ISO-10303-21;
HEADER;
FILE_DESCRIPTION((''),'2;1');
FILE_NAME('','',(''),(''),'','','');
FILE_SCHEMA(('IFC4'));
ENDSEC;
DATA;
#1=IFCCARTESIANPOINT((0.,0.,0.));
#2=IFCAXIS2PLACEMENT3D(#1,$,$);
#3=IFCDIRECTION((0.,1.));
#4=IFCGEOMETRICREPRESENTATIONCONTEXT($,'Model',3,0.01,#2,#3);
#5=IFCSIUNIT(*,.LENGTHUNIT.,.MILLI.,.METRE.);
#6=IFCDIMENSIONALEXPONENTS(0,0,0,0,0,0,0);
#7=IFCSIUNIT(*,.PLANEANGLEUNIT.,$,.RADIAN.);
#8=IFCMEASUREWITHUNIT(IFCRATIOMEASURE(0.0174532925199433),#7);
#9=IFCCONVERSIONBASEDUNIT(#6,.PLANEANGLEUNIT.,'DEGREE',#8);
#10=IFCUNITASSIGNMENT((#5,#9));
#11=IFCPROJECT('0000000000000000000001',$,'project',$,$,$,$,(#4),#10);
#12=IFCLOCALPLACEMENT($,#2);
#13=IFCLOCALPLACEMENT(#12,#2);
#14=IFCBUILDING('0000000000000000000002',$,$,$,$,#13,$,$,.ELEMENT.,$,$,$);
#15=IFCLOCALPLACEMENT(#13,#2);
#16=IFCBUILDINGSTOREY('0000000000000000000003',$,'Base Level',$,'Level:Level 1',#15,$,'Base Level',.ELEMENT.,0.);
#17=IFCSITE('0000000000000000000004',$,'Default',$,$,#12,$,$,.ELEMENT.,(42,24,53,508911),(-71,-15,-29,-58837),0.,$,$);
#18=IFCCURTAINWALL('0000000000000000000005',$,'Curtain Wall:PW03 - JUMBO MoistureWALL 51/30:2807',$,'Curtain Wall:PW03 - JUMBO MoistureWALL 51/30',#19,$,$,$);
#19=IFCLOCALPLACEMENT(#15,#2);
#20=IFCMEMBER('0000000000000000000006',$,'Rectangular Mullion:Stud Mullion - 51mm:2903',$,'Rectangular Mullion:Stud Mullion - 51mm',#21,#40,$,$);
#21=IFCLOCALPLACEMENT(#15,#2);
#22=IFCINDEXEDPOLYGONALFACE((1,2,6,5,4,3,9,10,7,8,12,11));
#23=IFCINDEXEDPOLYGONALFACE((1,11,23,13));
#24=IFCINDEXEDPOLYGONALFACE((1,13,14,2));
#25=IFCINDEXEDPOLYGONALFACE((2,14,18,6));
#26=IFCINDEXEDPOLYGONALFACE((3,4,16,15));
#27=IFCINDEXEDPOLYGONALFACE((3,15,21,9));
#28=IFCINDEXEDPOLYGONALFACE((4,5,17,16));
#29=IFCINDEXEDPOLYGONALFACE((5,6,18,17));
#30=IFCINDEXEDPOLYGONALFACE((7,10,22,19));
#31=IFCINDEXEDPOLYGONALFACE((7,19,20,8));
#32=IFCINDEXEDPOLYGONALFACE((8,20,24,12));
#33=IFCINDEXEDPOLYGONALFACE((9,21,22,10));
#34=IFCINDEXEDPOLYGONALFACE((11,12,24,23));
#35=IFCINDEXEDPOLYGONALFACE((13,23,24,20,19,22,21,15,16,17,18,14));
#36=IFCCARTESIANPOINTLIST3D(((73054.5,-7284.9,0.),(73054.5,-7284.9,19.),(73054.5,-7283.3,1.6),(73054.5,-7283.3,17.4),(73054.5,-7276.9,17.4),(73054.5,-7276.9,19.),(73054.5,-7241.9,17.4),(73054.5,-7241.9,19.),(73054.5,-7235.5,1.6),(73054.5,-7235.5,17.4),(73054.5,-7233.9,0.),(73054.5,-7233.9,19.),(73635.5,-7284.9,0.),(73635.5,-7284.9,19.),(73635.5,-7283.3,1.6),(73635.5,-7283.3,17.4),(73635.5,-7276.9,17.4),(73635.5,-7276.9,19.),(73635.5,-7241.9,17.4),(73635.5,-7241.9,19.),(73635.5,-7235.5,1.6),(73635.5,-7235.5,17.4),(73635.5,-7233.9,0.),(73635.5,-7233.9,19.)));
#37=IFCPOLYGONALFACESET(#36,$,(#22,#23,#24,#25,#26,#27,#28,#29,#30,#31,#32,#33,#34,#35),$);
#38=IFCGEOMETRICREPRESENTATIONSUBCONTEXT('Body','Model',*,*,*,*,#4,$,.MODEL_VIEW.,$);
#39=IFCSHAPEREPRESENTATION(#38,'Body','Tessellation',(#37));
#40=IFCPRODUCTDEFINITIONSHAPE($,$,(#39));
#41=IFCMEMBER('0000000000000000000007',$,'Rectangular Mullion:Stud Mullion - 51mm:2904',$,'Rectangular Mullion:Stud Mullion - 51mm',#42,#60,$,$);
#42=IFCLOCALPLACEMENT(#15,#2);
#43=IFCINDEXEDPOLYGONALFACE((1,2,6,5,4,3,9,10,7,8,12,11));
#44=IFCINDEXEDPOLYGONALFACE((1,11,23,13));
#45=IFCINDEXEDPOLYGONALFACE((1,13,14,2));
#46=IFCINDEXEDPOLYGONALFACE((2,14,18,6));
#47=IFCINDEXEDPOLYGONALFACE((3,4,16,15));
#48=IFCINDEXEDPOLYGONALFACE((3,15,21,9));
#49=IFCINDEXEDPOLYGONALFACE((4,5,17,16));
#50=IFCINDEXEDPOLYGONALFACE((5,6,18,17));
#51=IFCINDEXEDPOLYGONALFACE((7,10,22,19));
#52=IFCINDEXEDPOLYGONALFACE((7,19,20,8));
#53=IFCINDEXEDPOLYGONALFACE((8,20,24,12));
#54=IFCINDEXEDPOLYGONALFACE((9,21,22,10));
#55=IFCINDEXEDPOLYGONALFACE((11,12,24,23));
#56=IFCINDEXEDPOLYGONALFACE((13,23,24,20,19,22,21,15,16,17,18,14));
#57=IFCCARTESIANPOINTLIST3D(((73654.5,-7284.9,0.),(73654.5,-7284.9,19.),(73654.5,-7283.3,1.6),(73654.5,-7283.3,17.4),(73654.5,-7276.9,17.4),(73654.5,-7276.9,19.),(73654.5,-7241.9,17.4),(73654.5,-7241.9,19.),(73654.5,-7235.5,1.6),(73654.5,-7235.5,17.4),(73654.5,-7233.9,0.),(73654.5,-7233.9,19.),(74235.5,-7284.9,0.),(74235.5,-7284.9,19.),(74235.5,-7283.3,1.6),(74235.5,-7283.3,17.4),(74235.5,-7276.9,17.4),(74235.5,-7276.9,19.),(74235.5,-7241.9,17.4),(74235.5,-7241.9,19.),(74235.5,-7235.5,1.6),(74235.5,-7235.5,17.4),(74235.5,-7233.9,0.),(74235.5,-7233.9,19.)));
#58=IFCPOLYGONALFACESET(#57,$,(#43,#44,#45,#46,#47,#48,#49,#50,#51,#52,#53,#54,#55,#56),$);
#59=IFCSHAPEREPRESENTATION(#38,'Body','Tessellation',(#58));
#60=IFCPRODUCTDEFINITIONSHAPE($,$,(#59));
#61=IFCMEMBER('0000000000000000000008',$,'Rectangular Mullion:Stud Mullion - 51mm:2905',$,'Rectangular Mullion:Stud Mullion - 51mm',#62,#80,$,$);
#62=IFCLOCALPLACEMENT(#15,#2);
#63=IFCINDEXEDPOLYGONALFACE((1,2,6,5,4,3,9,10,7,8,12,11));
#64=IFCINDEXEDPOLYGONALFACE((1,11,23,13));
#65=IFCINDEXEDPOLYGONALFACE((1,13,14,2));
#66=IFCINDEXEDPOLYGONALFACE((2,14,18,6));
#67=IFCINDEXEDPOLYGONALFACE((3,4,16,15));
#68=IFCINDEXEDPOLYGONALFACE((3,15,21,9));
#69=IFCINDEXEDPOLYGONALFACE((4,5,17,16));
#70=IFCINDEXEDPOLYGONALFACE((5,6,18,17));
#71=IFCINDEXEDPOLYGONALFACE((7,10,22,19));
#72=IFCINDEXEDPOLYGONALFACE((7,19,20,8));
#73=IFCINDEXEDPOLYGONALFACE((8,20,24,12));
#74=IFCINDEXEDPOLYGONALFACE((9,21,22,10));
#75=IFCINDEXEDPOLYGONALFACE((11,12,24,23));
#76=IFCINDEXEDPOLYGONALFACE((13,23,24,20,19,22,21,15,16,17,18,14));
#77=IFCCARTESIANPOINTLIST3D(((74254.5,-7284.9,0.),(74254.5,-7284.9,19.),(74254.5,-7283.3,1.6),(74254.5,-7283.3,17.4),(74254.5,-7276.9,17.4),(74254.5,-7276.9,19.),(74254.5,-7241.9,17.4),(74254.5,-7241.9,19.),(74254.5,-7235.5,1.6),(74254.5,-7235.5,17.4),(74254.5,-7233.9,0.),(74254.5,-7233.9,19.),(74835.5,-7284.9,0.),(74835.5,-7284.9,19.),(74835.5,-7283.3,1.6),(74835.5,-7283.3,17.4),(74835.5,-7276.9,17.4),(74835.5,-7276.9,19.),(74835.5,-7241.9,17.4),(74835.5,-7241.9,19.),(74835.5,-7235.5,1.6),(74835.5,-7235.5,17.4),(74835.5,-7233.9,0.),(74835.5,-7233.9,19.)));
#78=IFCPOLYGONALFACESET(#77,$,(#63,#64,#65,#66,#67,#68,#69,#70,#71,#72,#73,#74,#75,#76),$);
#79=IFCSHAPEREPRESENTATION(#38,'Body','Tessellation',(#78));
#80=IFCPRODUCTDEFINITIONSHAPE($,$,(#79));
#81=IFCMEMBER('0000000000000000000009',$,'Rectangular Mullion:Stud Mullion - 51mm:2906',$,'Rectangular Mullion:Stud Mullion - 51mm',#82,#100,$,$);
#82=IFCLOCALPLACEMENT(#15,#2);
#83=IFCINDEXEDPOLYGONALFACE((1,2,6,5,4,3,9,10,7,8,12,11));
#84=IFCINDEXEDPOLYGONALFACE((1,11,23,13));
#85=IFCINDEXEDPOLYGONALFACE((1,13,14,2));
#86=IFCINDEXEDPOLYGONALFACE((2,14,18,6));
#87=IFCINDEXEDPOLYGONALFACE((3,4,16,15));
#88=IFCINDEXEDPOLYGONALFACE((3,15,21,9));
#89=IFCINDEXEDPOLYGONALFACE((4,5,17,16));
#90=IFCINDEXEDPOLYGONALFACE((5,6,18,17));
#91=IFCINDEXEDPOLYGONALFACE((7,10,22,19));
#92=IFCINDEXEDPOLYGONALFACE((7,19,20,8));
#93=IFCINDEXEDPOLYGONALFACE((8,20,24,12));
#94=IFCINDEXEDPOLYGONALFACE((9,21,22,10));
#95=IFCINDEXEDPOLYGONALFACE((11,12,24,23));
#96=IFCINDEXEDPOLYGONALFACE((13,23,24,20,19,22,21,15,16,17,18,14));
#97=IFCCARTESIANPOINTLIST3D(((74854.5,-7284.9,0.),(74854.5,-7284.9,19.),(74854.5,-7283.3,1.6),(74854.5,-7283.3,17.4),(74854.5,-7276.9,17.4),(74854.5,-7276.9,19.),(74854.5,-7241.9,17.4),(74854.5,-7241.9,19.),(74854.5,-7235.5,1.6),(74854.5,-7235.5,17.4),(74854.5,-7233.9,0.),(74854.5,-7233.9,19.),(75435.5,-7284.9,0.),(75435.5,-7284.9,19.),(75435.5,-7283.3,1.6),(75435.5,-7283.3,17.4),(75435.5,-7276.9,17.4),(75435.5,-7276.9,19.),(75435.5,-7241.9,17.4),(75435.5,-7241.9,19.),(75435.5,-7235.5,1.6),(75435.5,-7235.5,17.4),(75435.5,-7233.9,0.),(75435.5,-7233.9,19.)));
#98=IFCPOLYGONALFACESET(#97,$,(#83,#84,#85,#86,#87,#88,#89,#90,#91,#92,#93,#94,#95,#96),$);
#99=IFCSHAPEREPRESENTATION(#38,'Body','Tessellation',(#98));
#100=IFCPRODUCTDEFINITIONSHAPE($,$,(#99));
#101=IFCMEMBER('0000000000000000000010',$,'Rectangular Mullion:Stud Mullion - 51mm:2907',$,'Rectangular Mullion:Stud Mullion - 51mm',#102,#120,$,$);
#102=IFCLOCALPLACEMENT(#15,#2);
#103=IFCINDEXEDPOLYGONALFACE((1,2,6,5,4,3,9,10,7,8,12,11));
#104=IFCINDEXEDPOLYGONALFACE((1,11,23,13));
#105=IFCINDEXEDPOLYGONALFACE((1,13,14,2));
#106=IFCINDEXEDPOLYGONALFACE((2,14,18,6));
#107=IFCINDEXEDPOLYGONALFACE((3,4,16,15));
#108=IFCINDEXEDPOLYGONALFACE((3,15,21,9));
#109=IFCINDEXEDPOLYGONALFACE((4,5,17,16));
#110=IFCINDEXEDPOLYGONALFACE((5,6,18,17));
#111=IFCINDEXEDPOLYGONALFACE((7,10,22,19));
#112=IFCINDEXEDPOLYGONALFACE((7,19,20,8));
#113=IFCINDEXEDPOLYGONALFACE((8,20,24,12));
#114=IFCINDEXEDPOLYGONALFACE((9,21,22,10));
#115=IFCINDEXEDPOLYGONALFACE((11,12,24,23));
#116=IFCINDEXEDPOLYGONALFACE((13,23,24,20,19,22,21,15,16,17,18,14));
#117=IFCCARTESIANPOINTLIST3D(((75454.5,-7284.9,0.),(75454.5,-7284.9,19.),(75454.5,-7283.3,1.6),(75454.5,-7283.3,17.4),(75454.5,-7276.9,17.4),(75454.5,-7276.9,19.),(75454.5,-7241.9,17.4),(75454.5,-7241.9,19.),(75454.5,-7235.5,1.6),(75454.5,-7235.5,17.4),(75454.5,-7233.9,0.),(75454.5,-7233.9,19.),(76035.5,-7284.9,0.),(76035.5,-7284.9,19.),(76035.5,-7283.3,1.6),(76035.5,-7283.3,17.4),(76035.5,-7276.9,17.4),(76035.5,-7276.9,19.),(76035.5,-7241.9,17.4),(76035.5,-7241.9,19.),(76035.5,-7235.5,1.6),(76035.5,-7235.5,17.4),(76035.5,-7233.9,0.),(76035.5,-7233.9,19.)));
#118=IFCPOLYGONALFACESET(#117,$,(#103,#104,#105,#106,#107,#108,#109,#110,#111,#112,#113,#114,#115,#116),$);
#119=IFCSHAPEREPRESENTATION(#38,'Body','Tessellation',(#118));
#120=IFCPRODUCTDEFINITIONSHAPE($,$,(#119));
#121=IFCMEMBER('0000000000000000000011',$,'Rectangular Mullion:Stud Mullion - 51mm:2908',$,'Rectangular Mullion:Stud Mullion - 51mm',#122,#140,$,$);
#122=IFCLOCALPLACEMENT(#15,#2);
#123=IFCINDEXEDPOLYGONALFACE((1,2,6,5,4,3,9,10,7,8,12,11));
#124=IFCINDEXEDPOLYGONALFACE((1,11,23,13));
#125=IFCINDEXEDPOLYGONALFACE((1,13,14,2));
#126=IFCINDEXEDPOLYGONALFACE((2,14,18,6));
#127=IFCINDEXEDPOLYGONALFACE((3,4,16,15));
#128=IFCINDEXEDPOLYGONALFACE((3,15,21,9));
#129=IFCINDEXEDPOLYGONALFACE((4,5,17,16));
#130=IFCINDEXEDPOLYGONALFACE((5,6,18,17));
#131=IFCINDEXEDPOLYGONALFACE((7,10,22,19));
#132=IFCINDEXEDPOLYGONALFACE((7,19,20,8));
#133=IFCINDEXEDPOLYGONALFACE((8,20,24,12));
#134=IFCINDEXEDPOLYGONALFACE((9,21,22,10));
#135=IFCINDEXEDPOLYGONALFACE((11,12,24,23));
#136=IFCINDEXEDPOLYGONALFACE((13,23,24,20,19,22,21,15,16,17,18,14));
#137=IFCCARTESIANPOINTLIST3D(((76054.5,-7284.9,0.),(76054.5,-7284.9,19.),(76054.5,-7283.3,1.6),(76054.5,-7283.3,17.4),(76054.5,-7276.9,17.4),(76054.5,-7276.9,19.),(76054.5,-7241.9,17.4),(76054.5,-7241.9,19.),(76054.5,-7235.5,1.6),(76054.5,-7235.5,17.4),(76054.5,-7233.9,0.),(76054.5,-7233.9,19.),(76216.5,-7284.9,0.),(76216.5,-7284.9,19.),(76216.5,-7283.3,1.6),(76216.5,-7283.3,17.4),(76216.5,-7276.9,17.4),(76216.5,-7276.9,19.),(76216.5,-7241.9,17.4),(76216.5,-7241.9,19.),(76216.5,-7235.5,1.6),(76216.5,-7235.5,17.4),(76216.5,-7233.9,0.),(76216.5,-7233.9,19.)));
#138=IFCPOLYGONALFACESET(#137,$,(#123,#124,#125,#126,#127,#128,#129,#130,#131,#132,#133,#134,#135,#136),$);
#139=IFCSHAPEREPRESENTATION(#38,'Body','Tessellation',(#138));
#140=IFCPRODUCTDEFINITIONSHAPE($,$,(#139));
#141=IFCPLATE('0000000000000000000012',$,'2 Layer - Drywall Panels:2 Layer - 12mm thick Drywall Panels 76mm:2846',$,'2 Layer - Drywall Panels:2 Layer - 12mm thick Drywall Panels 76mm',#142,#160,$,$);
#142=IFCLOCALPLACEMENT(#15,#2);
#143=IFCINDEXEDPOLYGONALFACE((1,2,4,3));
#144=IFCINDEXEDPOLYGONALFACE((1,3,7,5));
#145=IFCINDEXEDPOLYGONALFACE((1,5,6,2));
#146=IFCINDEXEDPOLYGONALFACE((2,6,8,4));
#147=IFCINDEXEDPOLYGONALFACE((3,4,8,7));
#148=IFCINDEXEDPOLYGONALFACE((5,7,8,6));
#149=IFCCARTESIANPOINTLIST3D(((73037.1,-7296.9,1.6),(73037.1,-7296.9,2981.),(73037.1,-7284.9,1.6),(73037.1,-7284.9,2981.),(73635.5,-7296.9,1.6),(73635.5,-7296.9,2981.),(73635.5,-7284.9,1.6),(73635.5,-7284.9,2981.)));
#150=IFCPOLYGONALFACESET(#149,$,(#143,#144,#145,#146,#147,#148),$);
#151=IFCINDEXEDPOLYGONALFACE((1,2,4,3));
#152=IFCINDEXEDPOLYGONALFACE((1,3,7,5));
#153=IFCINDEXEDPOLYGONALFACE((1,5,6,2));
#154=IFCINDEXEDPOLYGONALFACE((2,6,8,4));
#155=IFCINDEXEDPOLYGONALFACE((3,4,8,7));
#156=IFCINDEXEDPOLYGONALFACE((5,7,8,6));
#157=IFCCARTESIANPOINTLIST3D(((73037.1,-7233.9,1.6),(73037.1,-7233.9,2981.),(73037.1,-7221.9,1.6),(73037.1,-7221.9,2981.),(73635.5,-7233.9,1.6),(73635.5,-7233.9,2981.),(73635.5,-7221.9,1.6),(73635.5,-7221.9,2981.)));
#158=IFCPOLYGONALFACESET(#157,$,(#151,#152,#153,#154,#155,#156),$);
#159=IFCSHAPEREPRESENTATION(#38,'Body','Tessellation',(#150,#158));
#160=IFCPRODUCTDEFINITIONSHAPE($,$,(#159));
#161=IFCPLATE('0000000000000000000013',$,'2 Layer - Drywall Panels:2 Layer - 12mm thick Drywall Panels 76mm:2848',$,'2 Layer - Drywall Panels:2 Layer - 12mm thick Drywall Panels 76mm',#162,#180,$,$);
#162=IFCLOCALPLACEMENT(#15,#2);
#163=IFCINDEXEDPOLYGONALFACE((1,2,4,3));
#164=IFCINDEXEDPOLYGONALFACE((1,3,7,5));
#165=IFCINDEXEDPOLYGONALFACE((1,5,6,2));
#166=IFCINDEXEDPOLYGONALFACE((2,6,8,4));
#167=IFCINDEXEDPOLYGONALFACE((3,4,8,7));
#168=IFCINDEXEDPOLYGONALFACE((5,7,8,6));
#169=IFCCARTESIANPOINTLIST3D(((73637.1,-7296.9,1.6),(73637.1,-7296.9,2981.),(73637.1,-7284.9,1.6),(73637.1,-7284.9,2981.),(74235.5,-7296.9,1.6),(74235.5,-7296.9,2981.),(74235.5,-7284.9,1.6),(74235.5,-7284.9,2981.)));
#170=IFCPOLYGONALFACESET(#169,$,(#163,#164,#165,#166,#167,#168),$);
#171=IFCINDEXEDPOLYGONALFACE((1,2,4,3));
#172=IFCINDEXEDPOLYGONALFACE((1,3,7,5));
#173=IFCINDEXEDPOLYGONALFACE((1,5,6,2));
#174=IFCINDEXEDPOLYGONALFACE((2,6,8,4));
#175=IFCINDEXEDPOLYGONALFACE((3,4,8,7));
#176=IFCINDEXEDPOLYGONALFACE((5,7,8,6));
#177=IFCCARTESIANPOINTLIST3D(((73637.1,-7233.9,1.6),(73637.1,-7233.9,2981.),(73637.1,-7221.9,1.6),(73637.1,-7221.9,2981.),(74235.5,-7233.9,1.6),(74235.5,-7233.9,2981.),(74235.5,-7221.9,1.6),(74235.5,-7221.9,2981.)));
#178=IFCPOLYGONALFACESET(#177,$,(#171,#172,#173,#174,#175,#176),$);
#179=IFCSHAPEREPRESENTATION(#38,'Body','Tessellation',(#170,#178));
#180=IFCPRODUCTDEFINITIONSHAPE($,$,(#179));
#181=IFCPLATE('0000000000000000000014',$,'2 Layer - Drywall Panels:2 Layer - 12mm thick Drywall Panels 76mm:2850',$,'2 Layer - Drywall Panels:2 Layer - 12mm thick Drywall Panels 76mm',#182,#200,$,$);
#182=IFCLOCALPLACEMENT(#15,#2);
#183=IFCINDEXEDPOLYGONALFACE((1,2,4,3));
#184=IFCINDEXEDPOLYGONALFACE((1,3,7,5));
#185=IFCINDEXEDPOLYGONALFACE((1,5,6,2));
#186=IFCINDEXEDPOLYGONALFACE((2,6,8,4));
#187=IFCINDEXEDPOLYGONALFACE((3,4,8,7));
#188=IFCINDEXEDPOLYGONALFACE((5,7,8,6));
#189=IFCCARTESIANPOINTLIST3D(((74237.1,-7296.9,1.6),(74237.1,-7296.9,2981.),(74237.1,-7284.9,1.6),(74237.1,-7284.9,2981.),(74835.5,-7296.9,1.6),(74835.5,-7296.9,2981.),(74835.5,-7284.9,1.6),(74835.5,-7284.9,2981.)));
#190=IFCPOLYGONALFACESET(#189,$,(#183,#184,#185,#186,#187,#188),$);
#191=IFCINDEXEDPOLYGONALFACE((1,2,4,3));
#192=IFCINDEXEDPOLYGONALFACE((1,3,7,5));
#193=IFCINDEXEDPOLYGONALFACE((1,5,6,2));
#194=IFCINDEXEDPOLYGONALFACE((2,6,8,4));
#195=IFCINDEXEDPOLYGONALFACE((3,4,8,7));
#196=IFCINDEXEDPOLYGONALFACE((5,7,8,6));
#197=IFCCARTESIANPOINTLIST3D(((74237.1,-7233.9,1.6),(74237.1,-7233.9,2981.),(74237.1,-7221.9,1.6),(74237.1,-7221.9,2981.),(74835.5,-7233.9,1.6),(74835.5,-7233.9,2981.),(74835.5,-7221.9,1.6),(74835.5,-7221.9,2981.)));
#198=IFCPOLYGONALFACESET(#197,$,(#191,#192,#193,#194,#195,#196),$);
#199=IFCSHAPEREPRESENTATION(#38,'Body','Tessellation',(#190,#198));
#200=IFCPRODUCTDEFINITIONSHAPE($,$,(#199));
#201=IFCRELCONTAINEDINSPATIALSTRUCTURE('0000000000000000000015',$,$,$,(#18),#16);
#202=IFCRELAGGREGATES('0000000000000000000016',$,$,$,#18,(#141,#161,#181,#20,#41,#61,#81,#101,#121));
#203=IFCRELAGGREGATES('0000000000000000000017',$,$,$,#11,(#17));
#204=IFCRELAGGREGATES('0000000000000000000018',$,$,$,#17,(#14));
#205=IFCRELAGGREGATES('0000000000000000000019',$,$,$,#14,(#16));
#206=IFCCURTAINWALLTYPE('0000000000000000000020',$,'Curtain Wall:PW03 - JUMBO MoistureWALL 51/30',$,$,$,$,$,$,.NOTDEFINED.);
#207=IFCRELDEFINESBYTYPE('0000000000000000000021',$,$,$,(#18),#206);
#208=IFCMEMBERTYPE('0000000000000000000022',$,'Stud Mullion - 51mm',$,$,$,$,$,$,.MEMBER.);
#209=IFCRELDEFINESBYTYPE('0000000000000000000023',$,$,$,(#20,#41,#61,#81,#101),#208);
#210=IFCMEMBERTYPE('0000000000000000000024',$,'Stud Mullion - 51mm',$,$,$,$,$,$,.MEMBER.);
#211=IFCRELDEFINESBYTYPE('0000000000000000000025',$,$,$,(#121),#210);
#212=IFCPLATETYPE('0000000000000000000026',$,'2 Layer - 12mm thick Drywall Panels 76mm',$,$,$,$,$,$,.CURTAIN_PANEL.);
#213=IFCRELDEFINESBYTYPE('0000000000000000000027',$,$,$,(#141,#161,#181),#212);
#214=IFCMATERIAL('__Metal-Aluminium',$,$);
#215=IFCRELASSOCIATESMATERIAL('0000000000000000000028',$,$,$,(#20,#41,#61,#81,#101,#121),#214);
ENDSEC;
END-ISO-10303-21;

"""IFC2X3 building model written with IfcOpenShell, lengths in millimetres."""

from ifc_helpers import new_model, entity, si_unit, converted_unit, direction, frame, frame_2d, origin, origin_2d_with_axis, place, context, subcontext, project, spatial, polyline, rectangle, outline, extrude, source, transform, mapped, material, type_object, type_shapes, element, aggregate, save


model = new_model("IFC2X3")

# Units and contexts
model_context = context("Model", 3, precision=0.01, world=origin(), true_north=direction((0.0, 1.0)))
body_context = subcontext(model_context, "Body", "Model", "MODEL_VIEW")
ifc_project = project(units=[si_unit("LENGTHUNIT", "METRE", prefix="MILLI"), converted_unit("PLANEANGLEUNIT", "DEGREE", entity("IfcRatioMeasure", 0.0174532925199433), si_unit("PLANEANGLEUNIT", "RADIAN"), dimensions=[0, 0, 0, 0, 0, 0, 0])], contexts=[model_context])

# Site, building, storey
site_placement = place(None, origin())
site = spatial("IfcSite", under=ifc_project, at=site_placement, Name="Default", CompositionType="ELEMENT", RefLatitude=(42, 24, 53, 508911), RefLongitude=(-71, -15, -29, -58837), RefElevation=0.0)
building_placement = place(site_placement, origin())
building = spatial("IfcBuilding", under=site, at=building_placement, CompositionType="ELEMENT")
storey_placement = place(building_placement, origin())
storey = spatial("IfcBuildingStorey", under=building, at=storey_placement, Name="Base Level", ObjectType="Level:Level 1", LongName="Base Level", CompositionType="ELEMENT", Elevation=0.0)

# Curtain wall, members, plates
curtain_wall_type = type_object("IfcCurtainWallType", Name="Curtain Wall:PW03 - JUMBO MoistureWALL 51/30", PredefinedType="NOTDEFINED")
curtain_wall_placement = place(building_placement, origin())
curtain_wall = element("IfcCurtainWall", 1, at=curtain_wall_placement, inside=storey, type_object=curtain_wall_type, Name="Curtain Wall:PW03 - JUMBO MoistureWALL 51/30:2807", ObjectType="Curtain Wall:PW03 - JUMBO MoistureWALL 51/30")
ifc_material = material(Name="__Metal-Aluminium")
member_type_1 = type_object("IfcMemberType", Name="Stud Mullion - 51mm", PredefinedType="MEMBER")
shared_shape_1 = source(origin(), body_context, "Body", "SweptSolid", [
    extrude(outline(polyline([(17.5, -6.6), (25.5, -6.6), (25.5, 12.4), (-25.5, 12.4), (-25.5, -6.6), (-17.5, -6.6), (-17.5, -5.0), (-23.9, -5.0), (-23.9, 10.8), (23.9, 10.8), (23.9, -5.0), (17.5, -5.0), (17.5, -6.6)])), frame((-12.4, 0.0, -581.0), z_axis=(0.0, 0.0, 1.0), x_axis=(0.0, -1.0, 0.0)), (0.0, 0.0, 1.0), 581.0),
])
type_shapes(member_type_1, [shared_shape_1])
member_1_placement = place(building_placement, frame((73054.5, -7259.4, 0.0), z_axis=(-1.0, 0.0, 0.0), x_axis=(0.0, 0.0, -1.0)))
member_1 = element("IfcMember", 2, at=member_1_placement, type_object=member_type_1, material=ifc_material, Name="Rectangular Mullion:Stud Mullion - 51mm:2903", ObjectType="Rectangular Mullion:Stud Mullion - 51mm", context=body_context, shape_type="MappedRepresentation", body=[
    mapped(shared_shape_1, transform((0.0, 0.0, 0.0), scale=1.0)),
])
member_2_placement = place(building_placement, frame((73654.5, -7259.4, 0.0), z_axis=(-1.0, 0.0, 0.0), x_axis=(0.0, 0.0, -1.0)))
member_2 = element("IfcMember", 3, at=member_2_placement, type_object=member_type_1, material=ifc_material, Name="Rectangular Mullion:Stud Mullion - 51mm:2904", ObjectType="Rectangular Mullion:Stud Mullion - 51mm", context=body_context, shape_type="MappedRepresentation", body=[
    mapped(shared_shape_1, transform((0.0, 0.0, 0.0), scale=1.0)),
])
member_3_placement = place(building_placement, frame((74254.5, -7259.4, 0.0), z_axis=(-1.0, 0.0, 0.0), x_axis=(0.0, 0.0, -1.0)))
member_3 = element("IfcMember", 4, at=member_3_placement, type_object=member_type_1, material=ifc_material, Name="Rectangular Mullion:Stud Mullion - 51mm:2905", ObjectType="Rectangular Mullion:Stud Mullion - 51mm", context=body_context, shape_type="MappedRepresentation", body=[
    mapped(shared_shape_1, transform((0.0, 0.0, 0.0), scale=1.0)),
])
member_4_placement = place(building_placement, frame((74854.5, -7259.4, 0.0), z_axis=(-1.0, 0.0, 0.0), x_axis=(0.0, 0.0, -1.0)))
member_4 = element("IfcMember", 5, at=member_4_placement, type_object=member_type_1, material=ifc_material, Name="Rectangular Mullion:Stud Mullion - 51mm:2906", ObjectType="Rectangular Mullion:Stud Mullion - 51mm", context=body_context, shape_type="MappedRepresentation", body=[
    mapped(shared_shape_1, transform((0.0, 0.0, 0.0), scale=1.0)),
])
member_5_placement = place(building_placement, frame((75454.5, -7259.4, 0.0), z_axis=(-1.0, 0.0, 0.0), x_axis=(0.0, 0.0, -1.0)))
member_5 = element("IfcMember", 6, at=member_5_placement, type_object=member_type_1, material=ifc_material, Name="Rectangular Mullion:Stud Mullion - 51mm:2907", ObjectType="Rectangular Mullion:Stud Mullion - 51mm", context=body_context, shape_type="MappedRepresentation", body=[
    mapped(shared_shape_1, transform((0.0, 0.0, 0.0), scale=1.0)),
])
member_type_2 = type_object("IfcMemberType", Name="Stud Mullion - 51mm", PredefinedType="MEMBER")
shared_shape_2 = source(origin(), body_context, "Body", "SweptSolid", [
    extrude(outline(polyline([(17.5, -6.6), (25.5, -6.6), (25.5, 12.4), (-25.5, 12.4), (-25.5, -6.6), (-17.5, -6.6), (-17.5, -5.0), (-23.9, -5.0), (-23.9, 10.8), (23.9, 10.8), (23.9, -5.0), (17.5, -5.0), (17.5, -6.6)])), frame((-12.4, 0.0, -162.0), z_axis=(0.0, 0.0, 1.0), x_axis=(0.0, -1.0, 0.0)), (0.0, 0.0, 1.0), 162.0),
])
type_shapes(member_type_2, [shared_shape_2])
member_6_placement = place(building_placement, frame((76054.5, -7259.4, 0.0), z_axis=(-1.0, 0.0, 0.0), x_axis=(0.0, 0.0, -1.0)))
member_6 = element("IfcMember", 7, at=member_6_placement, type_object=member_type_2, material=ifc_material, Name="Rectangular Mullion:Stud Mullion - 51mm:2908", ObjectType="Rectangular Mullion:Stud Mullion - 51mm", context=body_context, shape_type="MappedRepresentation", body=[
    mapped(shared_shape_2, transform((0.0, 0.0, 0.0), scale=1.0)),
])
plate_type_1 = type_object("IfcPlateType", Name="2 Layer - 12mm thick Drywall Panels 76mm", PredefinedType="CURTAIN_PANEL")
shared_shape_3 = source(origin(), body_context, "Body", "SweptSolid", [
    extrude(rectangle(XDim=598.4, YDim=12.0, at=origin_2d_with_axis()), frame((0.0, -31.5, 0.0), z_axis=(0.0, 0.0, 1.0), x_axis=(-1.0, 0.0, 0.0)), (0.0, 0.0, 1.0), 2979.4),
    extrude(rectangle(XDim=12.0, YDim=598.4, at=frame_2d((0.0, 0.0), x_axis=(1.0, 0.0))), frame((0.0, 31.5, 0.0), z_axis=(0.0, 0.0, 1.0), x_axis=(0.0, 1.0, 0.0)), (0.0, 0.0, 1.0), 2979.4),
])
type_shapes(plate_type_1, [shared_shape_3])
plate_1_placement = place(curtain_wall_placement, frame((73336.3, -7259.4, 1.6)))
plate_1 = element("IfcPlate", 8, at=plate_1_placement, type_object=plate_type_1, Name="2 Layer - Drywall Panels:2 Layer - 12mm thick Drywall Panels 76mm:2846", ObjectType="2 Layer - Drywall Panels:2 Layer - 12mm thick Drywall Panels 76mm", context=body_context, shape_type="MappedRepresentation", body=[
    mapped(shared_shape_3, transform((0.0, 0.0, 0.0), scale=1.0)),
])
plate_2_placement = place(curtain_wall_placement, frame((73936.3, -7259.4, 1.6)))
plate_2 = element("IfcPlate", 9, at=plate_2_placement, type_object=plate_type_1, Name="2 Layer - Drywall Panels:2 Layer - 12mm thick Drywall Panels 76mm:2848", ObjectType="2 Layer - Drywall Panels:2 Layer - 12mm thick Drywall Panels 76mm", context=body_context, shape_type="MappedRepresentation", body=[
    mapped(shared_shape_3, transform((0.0, 0.0, 0.0), scale=1.0)),
])
plate_3_placement = place(curtain_wall_placement, frame((74536.3, -7259.4, 1.6)))
plate_3 = element("IfcPlate", 10, at=plate_3_placement, type_object=plate_type_1, Name="2 Layer - Drywall Panels:2 Layer - 12mm thick Drywall Panels 76mm:2850", ObjectType="2 Layer - Drywall Panels:2 Layer - 12mm thick Drywall Panels 76mm", context=body_context, shape_type="MappedRepresentation", body=[
    mapped(shared_shape_3, transform((0.0, 0.0, 0.0), scale=1.0)),
])
aggregate(curtain_wall, [plate_1, plate_2, plate_3, member_1, member_2, member_3, member_4, member_5, member_6])

save(model, "model.ifc")
